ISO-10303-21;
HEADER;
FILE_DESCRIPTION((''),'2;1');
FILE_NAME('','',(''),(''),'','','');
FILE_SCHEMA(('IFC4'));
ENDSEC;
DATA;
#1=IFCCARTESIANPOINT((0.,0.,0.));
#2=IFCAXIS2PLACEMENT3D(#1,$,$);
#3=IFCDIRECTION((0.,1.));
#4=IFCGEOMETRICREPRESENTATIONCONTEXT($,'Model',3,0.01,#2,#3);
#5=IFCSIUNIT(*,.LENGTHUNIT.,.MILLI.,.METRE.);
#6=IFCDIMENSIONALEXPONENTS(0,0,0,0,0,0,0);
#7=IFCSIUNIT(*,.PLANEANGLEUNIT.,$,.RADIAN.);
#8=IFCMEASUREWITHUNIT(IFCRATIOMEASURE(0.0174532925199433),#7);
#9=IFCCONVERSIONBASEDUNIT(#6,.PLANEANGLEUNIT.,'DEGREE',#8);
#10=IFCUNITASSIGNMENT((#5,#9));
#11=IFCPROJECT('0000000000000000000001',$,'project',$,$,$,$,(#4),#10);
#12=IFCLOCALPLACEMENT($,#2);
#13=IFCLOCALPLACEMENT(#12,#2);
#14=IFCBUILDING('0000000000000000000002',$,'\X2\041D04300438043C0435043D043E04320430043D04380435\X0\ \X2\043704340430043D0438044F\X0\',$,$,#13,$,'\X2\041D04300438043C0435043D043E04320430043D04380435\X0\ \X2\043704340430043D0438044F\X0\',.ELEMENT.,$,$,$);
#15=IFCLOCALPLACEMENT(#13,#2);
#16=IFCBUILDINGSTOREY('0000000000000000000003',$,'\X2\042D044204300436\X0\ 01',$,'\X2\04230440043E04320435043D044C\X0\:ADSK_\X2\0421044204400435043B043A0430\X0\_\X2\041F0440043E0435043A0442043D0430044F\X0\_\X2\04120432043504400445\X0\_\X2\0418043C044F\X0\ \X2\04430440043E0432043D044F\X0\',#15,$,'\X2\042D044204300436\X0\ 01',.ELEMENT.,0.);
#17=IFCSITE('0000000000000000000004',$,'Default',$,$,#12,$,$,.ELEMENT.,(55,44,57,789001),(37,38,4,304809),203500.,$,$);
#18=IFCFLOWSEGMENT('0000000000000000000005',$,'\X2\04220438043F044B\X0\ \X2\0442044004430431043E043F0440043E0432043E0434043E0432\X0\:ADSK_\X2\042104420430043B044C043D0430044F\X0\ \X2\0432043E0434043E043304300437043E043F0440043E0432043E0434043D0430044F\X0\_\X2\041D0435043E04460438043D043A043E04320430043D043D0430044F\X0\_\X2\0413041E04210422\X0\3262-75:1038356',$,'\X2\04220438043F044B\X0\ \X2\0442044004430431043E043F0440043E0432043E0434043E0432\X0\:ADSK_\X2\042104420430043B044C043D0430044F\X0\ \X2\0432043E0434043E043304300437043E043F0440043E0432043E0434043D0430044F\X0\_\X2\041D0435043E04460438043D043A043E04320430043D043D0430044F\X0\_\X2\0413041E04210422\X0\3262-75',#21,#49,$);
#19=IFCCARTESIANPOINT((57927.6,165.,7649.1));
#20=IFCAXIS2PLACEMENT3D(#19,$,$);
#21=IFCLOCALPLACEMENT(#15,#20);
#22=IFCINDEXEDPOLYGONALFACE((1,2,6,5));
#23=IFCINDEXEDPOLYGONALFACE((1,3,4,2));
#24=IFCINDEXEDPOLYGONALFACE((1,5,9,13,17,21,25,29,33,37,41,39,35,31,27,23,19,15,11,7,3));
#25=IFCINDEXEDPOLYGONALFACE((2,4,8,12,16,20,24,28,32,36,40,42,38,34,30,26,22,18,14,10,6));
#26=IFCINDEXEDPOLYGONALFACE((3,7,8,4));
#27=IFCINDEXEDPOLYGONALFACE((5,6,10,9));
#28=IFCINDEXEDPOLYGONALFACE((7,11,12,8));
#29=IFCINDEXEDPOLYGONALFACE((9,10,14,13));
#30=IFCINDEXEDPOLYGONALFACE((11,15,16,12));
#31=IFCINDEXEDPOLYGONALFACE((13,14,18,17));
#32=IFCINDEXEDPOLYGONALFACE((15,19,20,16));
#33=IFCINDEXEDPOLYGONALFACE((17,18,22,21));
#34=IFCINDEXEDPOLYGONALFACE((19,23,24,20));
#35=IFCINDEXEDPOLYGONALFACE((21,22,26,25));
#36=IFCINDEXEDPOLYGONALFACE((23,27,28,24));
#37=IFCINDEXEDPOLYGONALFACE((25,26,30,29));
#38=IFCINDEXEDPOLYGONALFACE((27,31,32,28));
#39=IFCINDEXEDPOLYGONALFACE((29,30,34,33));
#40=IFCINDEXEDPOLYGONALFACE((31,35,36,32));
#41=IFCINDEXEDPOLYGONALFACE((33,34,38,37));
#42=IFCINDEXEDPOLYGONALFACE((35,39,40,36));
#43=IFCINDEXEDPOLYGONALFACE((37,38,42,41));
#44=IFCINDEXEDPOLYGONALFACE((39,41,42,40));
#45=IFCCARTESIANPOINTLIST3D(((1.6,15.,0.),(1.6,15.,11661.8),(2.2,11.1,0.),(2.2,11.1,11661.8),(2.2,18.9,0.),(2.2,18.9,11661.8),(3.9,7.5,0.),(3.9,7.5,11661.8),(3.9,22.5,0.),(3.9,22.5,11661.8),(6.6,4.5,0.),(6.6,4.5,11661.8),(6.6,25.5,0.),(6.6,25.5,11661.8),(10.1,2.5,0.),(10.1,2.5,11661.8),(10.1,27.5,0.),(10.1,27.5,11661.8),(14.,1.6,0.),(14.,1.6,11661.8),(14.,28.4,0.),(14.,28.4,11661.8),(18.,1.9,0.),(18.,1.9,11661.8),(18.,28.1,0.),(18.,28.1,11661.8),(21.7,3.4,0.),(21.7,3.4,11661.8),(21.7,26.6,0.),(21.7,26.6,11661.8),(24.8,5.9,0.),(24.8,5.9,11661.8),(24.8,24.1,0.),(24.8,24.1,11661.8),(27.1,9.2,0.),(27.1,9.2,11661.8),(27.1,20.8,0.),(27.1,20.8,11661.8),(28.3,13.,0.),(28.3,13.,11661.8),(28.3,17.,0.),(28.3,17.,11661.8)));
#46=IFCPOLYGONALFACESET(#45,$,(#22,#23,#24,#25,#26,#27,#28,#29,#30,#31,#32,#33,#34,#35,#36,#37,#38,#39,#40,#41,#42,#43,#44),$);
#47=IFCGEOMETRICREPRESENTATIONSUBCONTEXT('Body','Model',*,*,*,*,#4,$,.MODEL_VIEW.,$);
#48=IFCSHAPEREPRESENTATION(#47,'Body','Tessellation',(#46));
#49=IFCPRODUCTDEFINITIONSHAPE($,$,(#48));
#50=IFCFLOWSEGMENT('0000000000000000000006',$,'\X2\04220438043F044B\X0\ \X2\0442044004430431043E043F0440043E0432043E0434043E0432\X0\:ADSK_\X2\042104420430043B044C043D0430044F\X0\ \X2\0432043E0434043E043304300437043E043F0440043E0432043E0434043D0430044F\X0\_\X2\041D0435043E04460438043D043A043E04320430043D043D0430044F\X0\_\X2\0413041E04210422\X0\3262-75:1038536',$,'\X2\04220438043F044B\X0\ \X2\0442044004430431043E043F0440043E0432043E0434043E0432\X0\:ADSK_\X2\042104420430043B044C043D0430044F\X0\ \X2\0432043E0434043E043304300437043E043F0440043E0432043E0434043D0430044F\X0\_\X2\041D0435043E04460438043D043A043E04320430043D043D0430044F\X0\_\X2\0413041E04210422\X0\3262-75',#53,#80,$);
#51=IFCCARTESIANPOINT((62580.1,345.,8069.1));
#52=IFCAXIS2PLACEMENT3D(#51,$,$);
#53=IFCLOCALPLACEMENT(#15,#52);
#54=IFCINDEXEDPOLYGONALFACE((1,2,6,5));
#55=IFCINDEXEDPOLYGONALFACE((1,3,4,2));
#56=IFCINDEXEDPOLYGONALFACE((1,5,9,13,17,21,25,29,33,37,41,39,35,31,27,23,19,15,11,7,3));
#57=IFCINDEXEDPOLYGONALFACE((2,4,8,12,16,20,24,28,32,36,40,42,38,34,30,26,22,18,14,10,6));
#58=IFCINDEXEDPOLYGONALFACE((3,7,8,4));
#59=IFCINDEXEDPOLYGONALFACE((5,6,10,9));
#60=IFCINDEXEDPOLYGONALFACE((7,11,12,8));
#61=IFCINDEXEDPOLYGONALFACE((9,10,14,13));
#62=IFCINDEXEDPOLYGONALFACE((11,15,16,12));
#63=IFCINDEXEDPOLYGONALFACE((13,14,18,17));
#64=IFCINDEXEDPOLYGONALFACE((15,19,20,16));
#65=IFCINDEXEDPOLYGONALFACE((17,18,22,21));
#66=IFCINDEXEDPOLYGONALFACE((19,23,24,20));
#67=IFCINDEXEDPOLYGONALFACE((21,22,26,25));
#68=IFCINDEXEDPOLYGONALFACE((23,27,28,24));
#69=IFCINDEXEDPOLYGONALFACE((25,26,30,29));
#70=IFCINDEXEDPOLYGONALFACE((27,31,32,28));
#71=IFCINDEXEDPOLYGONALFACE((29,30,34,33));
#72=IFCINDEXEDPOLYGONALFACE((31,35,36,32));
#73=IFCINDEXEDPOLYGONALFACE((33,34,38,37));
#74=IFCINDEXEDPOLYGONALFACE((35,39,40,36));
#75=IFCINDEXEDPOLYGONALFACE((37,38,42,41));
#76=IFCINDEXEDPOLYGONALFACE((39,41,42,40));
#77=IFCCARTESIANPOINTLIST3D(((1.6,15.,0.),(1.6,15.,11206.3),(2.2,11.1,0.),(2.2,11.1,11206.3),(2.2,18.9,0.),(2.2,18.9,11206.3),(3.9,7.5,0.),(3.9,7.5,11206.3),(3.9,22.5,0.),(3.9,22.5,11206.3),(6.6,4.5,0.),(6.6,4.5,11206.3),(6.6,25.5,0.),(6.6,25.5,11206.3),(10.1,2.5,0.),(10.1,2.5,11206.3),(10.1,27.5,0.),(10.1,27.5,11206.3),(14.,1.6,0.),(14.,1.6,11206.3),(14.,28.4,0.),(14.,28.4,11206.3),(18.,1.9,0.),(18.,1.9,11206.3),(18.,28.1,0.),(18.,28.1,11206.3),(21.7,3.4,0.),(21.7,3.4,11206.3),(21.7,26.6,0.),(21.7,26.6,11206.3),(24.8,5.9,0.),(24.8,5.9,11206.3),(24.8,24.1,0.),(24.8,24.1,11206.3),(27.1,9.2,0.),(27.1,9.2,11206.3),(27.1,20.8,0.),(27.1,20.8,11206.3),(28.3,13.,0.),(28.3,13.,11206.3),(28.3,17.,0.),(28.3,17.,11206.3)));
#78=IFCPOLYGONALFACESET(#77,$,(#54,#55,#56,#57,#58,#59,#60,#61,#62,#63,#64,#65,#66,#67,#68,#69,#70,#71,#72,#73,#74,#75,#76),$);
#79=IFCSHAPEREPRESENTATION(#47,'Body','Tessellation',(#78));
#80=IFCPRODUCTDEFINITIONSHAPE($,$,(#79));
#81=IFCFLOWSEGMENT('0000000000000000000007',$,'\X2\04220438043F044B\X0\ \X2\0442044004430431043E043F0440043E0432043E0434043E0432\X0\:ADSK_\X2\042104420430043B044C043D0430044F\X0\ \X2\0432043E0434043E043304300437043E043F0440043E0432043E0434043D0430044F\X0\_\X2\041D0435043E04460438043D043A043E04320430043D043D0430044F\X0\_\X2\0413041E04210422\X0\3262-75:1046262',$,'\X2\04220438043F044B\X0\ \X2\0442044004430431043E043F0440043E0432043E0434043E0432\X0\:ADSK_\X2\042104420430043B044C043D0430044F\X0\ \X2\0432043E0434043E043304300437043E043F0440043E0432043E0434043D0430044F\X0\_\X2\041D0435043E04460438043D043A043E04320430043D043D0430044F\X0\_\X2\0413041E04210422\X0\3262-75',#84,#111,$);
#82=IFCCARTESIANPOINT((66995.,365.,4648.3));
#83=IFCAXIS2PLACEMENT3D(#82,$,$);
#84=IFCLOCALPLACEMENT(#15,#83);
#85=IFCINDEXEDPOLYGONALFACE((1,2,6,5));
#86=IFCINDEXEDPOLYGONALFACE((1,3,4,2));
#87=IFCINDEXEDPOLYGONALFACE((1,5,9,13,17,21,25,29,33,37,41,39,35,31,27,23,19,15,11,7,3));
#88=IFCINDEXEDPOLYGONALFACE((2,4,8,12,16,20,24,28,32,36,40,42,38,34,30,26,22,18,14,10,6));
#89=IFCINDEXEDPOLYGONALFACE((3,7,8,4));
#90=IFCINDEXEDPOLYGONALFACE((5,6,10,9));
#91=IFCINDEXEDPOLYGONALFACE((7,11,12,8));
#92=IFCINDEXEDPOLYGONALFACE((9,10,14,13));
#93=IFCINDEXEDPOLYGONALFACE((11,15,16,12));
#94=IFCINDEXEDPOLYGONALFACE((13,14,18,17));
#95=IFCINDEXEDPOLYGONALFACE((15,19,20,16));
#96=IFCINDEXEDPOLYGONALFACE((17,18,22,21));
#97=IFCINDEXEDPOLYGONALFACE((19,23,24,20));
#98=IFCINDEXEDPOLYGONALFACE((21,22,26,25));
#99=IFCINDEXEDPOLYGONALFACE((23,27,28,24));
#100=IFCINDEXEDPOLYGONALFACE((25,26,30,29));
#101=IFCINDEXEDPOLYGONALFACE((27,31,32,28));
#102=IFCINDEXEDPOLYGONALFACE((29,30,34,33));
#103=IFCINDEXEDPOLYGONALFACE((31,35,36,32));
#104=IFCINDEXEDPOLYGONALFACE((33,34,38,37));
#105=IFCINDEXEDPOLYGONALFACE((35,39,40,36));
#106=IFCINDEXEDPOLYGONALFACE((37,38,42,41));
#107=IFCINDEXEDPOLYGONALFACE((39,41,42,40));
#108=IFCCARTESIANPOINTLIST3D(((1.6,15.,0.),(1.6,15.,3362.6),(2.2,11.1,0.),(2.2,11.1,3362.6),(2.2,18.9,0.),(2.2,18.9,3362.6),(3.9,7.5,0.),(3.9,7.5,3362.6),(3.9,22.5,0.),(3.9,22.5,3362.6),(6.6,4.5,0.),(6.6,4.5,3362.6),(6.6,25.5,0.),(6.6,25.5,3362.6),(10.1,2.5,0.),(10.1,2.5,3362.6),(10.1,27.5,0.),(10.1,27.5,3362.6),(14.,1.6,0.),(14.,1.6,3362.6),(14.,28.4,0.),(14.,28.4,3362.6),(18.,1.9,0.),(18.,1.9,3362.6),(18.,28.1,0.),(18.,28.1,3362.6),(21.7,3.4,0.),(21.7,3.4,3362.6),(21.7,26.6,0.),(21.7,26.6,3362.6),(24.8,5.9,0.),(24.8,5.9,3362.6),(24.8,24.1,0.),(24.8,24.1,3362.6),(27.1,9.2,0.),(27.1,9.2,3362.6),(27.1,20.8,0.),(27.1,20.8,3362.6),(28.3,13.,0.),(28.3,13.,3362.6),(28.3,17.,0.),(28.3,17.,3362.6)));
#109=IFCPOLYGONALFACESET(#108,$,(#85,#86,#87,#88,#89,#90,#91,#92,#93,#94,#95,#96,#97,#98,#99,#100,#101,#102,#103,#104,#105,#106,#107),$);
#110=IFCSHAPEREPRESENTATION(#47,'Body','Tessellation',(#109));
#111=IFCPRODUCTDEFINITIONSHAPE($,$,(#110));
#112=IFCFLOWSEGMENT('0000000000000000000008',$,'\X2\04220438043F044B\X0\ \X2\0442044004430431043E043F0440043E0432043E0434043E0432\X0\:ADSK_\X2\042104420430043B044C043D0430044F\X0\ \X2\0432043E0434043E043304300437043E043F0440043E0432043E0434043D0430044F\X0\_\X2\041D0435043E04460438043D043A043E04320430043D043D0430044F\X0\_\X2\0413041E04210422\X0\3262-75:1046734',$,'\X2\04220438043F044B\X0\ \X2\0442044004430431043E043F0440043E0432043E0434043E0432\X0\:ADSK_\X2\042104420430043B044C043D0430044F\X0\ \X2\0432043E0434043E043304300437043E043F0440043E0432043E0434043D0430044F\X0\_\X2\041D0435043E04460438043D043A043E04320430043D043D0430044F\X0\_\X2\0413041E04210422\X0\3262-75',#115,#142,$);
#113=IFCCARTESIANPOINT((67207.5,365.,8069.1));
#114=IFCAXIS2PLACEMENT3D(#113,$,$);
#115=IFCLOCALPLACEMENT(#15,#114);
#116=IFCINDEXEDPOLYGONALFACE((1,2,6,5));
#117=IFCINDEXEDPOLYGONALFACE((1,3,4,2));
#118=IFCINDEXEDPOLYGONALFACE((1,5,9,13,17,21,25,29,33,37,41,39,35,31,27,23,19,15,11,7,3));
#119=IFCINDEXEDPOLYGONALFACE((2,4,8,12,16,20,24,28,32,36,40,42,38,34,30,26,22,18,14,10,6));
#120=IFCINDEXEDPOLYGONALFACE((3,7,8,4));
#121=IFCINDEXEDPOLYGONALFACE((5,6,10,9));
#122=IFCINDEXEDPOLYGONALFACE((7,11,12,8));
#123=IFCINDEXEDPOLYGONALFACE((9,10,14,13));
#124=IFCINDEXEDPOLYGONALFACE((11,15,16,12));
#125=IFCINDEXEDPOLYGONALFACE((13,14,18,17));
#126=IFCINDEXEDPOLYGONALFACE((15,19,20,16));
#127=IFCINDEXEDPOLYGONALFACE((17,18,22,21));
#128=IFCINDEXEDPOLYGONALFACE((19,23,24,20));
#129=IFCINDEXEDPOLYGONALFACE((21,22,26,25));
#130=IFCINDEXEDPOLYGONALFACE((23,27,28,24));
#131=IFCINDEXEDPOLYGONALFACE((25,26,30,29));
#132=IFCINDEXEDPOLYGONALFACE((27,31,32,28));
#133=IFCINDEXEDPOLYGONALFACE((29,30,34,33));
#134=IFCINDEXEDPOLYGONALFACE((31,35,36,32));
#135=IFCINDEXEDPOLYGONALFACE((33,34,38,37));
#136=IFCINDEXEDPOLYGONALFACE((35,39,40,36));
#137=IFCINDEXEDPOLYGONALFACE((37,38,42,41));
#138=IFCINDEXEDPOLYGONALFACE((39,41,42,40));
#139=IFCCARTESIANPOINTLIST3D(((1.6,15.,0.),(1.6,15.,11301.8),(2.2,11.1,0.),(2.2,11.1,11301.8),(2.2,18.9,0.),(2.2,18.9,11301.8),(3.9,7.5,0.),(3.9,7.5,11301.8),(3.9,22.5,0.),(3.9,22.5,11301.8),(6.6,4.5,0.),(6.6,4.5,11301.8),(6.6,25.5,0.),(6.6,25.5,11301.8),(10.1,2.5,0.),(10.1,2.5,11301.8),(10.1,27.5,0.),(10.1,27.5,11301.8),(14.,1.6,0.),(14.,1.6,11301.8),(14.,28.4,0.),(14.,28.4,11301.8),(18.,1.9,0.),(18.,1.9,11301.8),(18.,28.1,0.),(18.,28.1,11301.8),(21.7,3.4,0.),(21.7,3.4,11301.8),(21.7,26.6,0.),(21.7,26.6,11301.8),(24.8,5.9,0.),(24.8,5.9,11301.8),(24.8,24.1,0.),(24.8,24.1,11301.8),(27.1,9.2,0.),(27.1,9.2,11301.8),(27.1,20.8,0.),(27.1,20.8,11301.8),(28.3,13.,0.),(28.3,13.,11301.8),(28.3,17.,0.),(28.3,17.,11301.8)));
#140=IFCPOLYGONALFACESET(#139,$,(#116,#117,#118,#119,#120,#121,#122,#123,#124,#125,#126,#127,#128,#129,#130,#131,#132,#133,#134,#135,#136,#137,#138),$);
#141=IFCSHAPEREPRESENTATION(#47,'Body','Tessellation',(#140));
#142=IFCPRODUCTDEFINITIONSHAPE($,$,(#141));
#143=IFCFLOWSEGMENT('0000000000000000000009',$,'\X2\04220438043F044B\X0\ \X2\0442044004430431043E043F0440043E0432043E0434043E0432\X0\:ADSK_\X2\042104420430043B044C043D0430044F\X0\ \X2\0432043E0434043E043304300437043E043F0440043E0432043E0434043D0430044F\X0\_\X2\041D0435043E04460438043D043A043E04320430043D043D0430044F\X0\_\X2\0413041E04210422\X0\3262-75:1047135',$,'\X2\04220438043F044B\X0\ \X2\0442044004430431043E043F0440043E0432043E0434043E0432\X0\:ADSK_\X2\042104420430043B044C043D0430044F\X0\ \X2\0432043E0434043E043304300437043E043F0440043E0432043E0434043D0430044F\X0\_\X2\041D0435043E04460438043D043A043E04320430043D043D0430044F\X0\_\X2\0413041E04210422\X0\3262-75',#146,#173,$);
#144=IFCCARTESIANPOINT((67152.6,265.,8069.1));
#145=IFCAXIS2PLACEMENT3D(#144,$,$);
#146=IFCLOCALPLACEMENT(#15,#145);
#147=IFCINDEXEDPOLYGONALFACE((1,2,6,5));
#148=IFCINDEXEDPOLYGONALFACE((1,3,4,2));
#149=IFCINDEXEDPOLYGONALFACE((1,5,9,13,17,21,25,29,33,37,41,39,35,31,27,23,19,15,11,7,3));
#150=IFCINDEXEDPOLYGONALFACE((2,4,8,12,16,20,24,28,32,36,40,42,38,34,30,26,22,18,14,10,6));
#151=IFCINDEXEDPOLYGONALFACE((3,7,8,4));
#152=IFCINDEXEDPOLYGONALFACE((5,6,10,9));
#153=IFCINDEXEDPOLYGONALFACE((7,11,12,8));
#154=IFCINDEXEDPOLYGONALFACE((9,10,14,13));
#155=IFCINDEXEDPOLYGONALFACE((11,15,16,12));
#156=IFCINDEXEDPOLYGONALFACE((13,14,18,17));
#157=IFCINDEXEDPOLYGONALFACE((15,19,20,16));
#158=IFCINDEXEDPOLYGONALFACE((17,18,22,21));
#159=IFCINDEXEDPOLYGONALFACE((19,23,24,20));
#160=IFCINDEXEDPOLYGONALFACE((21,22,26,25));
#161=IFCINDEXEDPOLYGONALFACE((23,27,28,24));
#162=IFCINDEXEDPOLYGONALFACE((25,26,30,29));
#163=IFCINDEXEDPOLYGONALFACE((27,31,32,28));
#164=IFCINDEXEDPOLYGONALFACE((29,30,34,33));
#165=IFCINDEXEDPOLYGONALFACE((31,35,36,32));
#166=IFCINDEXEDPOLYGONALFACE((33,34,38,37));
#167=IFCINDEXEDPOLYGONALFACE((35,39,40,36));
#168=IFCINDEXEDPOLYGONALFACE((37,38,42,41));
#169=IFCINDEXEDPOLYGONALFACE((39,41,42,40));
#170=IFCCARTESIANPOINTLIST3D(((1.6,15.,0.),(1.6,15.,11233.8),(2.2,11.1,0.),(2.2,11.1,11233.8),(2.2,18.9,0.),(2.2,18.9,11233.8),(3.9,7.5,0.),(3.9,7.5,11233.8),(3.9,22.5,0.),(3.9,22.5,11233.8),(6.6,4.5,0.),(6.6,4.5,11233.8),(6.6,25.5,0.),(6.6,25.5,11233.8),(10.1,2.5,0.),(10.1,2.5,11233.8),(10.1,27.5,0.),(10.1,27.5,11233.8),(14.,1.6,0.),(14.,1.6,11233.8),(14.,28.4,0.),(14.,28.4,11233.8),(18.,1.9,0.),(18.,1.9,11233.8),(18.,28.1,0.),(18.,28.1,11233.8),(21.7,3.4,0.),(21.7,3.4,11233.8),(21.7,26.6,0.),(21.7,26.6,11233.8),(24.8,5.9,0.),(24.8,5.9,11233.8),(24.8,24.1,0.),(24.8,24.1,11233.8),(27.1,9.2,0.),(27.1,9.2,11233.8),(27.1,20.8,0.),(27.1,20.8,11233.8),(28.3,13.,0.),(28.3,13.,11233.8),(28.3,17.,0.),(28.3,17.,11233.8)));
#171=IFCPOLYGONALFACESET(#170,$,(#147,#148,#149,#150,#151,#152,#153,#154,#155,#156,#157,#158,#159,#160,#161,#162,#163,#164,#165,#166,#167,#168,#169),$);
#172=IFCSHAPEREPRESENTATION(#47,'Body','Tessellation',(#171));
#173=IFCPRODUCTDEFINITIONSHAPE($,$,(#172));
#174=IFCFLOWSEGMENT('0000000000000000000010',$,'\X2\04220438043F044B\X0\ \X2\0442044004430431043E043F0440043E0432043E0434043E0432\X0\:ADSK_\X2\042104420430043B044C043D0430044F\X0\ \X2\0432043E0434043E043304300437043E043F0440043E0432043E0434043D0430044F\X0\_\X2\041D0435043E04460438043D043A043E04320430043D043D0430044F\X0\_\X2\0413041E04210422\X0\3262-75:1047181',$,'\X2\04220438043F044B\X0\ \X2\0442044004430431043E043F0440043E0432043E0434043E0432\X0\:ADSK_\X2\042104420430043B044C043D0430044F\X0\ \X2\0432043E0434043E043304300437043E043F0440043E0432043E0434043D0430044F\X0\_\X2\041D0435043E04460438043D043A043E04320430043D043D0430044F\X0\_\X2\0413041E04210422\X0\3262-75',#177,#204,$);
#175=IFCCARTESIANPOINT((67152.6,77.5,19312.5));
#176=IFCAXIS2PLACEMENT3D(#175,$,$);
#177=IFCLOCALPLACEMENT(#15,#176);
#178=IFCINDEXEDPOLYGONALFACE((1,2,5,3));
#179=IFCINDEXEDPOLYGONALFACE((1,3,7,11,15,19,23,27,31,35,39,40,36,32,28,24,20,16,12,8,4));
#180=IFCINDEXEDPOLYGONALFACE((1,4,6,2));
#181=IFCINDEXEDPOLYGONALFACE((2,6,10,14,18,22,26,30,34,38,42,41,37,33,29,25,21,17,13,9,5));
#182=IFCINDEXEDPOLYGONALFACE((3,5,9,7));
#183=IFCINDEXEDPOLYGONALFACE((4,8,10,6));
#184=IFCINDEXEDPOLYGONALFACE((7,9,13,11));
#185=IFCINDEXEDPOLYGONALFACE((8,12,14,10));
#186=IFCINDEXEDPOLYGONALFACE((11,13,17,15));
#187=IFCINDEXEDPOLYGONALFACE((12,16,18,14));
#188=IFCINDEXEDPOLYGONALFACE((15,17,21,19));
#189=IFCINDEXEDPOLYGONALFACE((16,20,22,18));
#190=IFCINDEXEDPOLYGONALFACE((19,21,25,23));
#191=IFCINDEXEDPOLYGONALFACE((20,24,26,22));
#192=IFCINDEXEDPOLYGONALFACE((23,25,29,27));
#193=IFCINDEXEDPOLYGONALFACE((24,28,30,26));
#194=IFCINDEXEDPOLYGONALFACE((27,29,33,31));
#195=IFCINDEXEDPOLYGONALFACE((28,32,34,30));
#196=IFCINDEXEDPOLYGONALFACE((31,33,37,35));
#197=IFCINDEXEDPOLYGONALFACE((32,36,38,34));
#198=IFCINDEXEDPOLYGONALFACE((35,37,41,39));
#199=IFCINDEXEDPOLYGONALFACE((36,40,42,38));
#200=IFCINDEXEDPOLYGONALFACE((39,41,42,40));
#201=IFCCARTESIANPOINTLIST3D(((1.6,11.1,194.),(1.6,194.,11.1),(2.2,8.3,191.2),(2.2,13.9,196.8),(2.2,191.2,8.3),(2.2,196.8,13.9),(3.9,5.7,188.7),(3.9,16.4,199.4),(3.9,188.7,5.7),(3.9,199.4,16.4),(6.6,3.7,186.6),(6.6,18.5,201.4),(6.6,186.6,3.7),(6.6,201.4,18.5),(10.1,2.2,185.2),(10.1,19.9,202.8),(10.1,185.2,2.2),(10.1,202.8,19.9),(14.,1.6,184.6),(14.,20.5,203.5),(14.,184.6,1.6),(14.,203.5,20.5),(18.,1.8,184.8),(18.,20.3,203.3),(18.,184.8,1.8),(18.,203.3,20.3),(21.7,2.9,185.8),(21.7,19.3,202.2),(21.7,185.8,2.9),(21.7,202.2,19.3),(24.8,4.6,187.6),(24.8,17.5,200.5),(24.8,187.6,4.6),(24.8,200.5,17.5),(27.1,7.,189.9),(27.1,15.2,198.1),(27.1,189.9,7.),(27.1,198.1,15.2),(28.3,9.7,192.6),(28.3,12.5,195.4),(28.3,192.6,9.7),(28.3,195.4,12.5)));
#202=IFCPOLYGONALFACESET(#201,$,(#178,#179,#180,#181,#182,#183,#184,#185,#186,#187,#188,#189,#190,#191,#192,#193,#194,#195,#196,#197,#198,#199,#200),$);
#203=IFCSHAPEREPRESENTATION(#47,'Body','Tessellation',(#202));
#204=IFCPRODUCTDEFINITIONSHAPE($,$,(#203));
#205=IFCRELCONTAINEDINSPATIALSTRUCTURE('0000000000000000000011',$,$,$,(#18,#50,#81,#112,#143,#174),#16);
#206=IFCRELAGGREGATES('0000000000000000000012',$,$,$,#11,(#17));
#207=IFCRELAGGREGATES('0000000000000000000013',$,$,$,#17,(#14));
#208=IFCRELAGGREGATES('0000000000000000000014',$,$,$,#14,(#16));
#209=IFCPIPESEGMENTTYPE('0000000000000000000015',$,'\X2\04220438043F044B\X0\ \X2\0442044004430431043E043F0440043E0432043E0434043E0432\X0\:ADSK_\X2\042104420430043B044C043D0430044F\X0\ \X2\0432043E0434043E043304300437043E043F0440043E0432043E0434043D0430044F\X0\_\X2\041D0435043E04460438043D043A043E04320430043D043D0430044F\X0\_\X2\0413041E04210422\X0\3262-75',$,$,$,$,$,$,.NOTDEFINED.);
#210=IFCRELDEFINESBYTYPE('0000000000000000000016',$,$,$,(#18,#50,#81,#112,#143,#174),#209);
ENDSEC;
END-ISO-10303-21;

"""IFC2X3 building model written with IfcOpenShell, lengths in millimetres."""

from ifc_helpers import new_model, entity, si_unit, converted_unit, direction, frame, origin, origin_2d_with_axis, place, context, subcontext, project, spatial, circle, extrude, type_object, element, save


model = new_model("IFC2X3")

# Units and contexts
model_context = context("Model", 3, precision=0.01, world=origin(), true_north=direction((0.0, 1.0)))
body_context = subcontext(model_context, "Body", "Model", "MODEL_VIEW")
ifc_project = project(units=[si_unit("LENGTHUNIT", "METRE", prefix="MILLI"), converted_unit("PLANEANGLEUNIT", "DEGREE", entity("IfcRatioMeasure", 0.0174532925199433), si_unit("PLANEANGLEUNIT", "RADIAN"), dimensions=[0, 0, 0, 0, 0, 0, 0])], contexts=[model_context])

# Site, building, storey
site_placement = place(None, origin())
site = spatial("IfcSite", under=ifc_project, at=site_placement, Name="Default", CompositionType="ELEMENT", RefLatitude=(55, 44, 57, 789001), RefLongitude=(37, 38, 4, 304809), RefElevation=203500.0)
building_placement = place(site_placement, origin())
building = spatial("IfcBuilding", under=site, at=building_placement, Name="Наименование здания", LongName="Наименование здания", CompositionType="ELEMENT")
storey_placement = place(building_placement, origin())
storey = spatial("IfcBuildingStorey", under=building, at=storey_placement, Name="Этаж 01", ObjectType="Уровень:ADSK_Стрелка_Проектная_Вверх_Имя уровня", LongName="Этаж 01", CompositionType="ELEMENT", Elevation=0.0)

# Flow segments
pipe_segment_type = type_object("IfcPipeSegmentType", Name="Типы трубопроводов:ADSK_Стальная водогазопроводная_Неоцинкованная_ГОСТ3262-75", PredefinedType="NOTDEFINED")
flow_segment_1_placement = place(storey_placement, frame((57927.6, 165.0, 7649.1)))
element("IfcFlowSegment", 1, at=flow_segment_1_placement, inside=storey, type_object=pipe_segment_type, Name="Типы трубопроводов:ADSK_Стальная водогазопроводная_Неоцинкованная_ГОСТ3262-75:1038356", ObjectType="Типы трубопроводов:ADSK_Стальная водогазопроводная_Неоцинкованная_ГОСТ3262-75", context=body_context, shape_type="SweptSolid", body=[
    extrude(circle(Radius=13.4, at=origin_2d_with_axis()), frame((15.0, 15.0, 0.0), z_axis=(0.0, 0.0, 1.0), x_axis=(-1.0, 0.0, 0.0)), (0.0, 0.0, 1.0), 11661.8),
])
flow_segment_2_placement = place(storey_placement, frame((62580.1, 345.0, 8069.1)))
element("IfcFlowSegment", 2, at=flow_segment_2_placement, inside=storey, type_object=pipe_segment_type, Name="Типы трубопроводов:ADSK_Стальная водогазопроводная_Неоцинкованная_ГОСТ3262-75:1038536", ObjectType="Типы трубопроводов:ADSK_Стальная водогазопроводная_Неоцинкованная_ГОСТ3262-75", context=body_context, shape_type="SweptSolid", body=[
    extrude(circle(Radius=13.4, at=origin_2d_with_axis()), frame((15.0, 15.0, 0.0), z_axis=(0.0, 0.0, 1.0), x_axis=(-1.0, 0.0, 0.0)), (0.0, 0.0, 1.0), 11206.3),
])
flow_segment_3_placement = place(storey_placement, frame((66995.0, 365.0, 4648.3)))
element("IfcFlowSegment", 3, at=flow_segment_3_placement, inside=storey, type_object=pipe_segment_type, Name="Типы трубопроводов:ADSK_Стальная водогазопроводная_Неоцинкованная_ГОСТ3262-75:1046262", ObjectType="Типы трубопроводов:ADSK_Стальная водогазопроводная_Неоцинкованная_ГОСТ3262-75", context=body_context, shape_type="SweptSolid", body=[
    extrude(circle(Radius=13.4, at=origin_2d_with_axis()), frame((15.0, 15.0, 0.0), z_axis=(0.0, 0.0, 1.0), x_axis=(-1.0, 0.0, 0.0)), (0.0, 0.0, 1.0), 3362.6),
])
flow_segment_4_placement = place(storey_placement, frame((67207.5, 365.0, 8069.1)))
element("IfcFlowSegment", 4, at=flow_segment_4_placement, inside=storey, type_object=pipe_segment_type, Name="Типы трубопроводов:ADSK_Стальная водогазопроводная_Неоцинкованная_ГОСТ3262-75:1046734", ObjectType="Типы трубопроводов:ADSK_Стальная водогазопроводная_Неоцинкованная_ГОСТ3262-75", context=body_context, shape_type="SweptSolid", body=[
    extrude(circle(Radius=13.4, at=origin_2d_with_axis()), frame((15.0, 15.0, 0.0), z_axis=(0.0, 0.0, 1.0), x_axis=(-1.0, 0.0, 0.0)), (0.0, 0.0, 1.0), 11301.8),
])
flow_segment_5_placement = place(storey_placement, frame((67152.6, 265.0, 8069.1)))
element("IfcFlowSegment", 5, at=flow_segment_5_placement, inside=storey, type_object=pipe_segment_type, Name="Типы трубопроводов:ADSK_Стальная водогазопроводная_Неоцинкованная_ГОСТ3262-75:1047135", ObjectType="Типы трубопроводов:ADSK_Стальная водогазопроводная_Неоцинкованная_ГОСТ3262-75", context=body_context, shape_type="SweptSolid", body=[
    extrude(circle(Radius=13.4, at=origin_2d_with_axis()), frame((15.0, 15.0, 0.0), z_axis=(0.0, 0.0, 1.0), x_axis=(-1.0, 0.0, 0.0)), (0.0, 0.0, 1.0), 11233.8),
])
flow_segment_6_placement = place(storey_placement, frame((67152.6, 77.5, 19312.5)))
element("IfcFlowSegment", 6, at=flow_segment_6_placement, inside=storey, type_object=pipe_segment_type, Name="Типы трубопроводов:ADSK_Стальная водогазопроводная_Неоцинкованная_ГОСТ3262-75:1047181", ObjectType="Типы трубопроводов:ADSK_Стальная водогазопроводная_Неоцинкованная_ГОСТ3262-75", context=body_context, shape_type="SweptSolid", body=[
    extrude(circle(Radius=13.4, at=origin_2d_with_axis()), frame((15.0, 194.0, 11.1), z_axis=(0.0, -0.707107, 0.707107), x_axis=(-1.0, 0.0, 0.0)), (0.0, 0.0, 1.0), 258.7),
])

save(model, "model.ifc")
